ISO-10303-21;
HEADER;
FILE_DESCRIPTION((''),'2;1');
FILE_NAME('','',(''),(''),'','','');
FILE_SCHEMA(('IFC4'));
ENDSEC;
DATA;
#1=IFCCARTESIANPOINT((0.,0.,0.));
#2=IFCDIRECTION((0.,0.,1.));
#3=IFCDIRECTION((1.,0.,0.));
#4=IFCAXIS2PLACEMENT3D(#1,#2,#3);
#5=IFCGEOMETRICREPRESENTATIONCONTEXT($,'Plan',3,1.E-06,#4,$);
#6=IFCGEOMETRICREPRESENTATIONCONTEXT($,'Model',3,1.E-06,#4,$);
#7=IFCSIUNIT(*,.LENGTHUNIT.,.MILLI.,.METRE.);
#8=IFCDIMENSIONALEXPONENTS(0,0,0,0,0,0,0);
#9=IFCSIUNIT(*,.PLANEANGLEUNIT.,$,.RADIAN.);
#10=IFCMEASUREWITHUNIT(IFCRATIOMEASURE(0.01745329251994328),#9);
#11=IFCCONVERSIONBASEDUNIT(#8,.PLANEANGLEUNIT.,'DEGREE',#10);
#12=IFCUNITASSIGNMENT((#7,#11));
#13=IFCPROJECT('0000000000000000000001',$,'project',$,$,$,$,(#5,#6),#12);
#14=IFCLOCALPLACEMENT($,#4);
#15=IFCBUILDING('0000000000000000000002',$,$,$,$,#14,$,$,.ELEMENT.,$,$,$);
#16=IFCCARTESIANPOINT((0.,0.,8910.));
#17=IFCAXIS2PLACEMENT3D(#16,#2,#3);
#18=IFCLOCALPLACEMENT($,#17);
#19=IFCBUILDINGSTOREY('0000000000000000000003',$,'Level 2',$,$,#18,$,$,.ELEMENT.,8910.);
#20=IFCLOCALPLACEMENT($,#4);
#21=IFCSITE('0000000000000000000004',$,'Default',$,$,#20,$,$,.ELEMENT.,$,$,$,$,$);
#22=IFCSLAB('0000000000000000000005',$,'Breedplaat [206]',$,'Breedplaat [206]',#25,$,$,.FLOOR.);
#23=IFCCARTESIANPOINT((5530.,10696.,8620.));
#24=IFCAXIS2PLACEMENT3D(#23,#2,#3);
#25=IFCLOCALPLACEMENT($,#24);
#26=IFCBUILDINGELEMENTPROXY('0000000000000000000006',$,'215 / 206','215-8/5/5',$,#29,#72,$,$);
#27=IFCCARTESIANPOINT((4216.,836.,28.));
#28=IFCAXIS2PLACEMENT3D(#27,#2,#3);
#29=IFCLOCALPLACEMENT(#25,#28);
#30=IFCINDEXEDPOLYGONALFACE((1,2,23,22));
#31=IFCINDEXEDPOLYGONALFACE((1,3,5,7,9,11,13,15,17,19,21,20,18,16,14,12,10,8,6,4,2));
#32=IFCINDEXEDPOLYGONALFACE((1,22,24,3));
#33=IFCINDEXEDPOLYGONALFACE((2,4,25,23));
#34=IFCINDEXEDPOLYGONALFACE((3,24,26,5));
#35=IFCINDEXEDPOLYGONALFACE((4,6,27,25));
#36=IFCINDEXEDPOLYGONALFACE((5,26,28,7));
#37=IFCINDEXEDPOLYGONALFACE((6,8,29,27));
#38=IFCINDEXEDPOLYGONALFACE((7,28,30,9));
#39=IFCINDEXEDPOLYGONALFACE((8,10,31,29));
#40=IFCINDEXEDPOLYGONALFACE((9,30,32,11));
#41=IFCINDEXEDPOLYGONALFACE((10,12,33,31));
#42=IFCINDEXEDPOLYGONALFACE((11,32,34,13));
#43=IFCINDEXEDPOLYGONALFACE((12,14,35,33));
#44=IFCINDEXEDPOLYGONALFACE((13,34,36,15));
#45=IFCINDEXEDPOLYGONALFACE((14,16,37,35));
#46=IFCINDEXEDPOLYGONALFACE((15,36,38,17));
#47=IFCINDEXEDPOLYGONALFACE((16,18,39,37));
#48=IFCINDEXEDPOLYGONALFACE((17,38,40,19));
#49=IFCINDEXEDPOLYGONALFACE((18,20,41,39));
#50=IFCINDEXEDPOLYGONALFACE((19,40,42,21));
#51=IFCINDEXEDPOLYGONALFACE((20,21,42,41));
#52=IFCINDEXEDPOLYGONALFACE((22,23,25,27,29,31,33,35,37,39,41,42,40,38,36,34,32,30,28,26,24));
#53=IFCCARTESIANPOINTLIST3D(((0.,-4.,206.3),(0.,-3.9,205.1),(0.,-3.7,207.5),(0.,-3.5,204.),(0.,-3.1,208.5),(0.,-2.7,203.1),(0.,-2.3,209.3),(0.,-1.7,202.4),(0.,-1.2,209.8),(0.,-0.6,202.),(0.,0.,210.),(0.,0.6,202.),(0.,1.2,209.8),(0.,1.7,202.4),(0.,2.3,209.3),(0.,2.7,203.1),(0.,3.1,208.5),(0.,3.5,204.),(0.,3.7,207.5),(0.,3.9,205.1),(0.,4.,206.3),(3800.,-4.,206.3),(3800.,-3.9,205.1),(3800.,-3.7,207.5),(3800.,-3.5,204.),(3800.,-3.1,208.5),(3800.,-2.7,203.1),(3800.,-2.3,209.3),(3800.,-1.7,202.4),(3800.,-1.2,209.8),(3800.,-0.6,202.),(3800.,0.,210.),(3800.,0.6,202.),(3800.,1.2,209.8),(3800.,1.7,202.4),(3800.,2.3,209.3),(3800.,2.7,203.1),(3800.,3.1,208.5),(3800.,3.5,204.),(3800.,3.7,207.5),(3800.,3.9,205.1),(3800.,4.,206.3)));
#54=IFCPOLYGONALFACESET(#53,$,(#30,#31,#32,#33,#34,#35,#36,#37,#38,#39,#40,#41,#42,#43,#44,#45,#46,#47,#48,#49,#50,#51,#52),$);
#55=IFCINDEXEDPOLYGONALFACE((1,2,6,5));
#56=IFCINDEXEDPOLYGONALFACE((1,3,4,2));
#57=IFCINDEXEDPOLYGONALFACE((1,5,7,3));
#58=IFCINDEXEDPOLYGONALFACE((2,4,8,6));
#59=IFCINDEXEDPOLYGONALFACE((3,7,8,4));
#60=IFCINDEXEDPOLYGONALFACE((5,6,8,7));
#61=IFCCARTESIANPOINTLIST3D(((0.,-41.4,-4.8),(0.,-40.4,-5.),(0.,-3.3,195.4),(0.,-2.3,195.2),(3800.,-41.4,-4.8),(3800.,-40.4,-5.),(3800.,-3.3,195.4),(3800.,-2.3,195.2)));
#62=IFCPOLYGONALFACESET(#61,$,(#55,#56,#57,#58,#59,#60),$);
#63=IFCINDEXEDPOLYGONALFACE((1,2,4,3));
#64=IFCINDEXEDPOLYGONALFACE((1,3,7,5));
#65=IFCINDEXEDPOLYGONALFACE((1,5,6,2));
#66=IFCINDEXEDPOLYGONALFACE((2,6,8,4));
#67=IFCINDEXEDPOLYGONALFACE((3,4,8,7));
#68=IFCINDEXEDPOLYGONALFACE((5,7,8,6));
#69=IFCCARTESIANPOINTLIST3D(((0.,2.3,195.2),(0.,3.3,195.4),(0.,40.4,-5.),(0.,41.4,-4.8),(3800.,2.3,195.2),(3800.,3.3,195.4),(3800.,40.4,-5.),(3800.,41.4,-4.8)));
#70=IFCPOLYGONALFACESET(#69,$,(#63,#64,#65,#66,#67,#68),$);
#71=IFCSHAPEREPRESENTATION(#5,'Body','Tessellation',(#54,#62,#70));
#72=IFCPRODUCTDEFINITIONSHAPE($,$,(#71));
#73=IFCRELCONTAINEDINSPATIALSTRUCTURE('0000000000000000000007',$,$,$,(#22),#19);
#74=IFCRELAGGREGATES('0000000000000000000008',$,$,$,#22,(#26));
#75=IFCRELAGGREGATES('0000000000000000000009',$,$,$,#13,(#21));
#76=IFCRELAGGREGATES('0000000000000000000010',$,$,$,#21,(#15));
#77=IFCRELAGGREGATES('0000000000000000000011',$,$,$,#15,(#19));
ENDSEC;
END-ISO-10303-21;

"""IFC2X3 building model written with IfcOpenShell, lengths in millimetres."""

from ifc_helpers import new_model, entity, si_unit, converted_unit, frame, origin_with_axes, origin_2d_with_axis, place, context, project, spatial, rectangle, circle, extrude, element, aggregate, save


model = new_model("IFC2X3")

# Units and contexts
plan_context = context("Plan", 3, precision=1e-06, world=origin_with_axes())
model_context = context("Model", 3, precision=1e-06, world=origin_with_axes())
ifc_project = project(units=[si_unit("LENGTHUNIT", "METRE", prefix="MILLI"), converted_unit("PLANEANGLEUNIT", "DEGREE", entity("IfcRatioMeasure", 0.01745329251994328), si_unit("PLANEANGLEUNIT", "RADIAN"), dimensions=[0, 0, 0, 0, 0, 0, 0])], contexts=[plan_context, model_context])

# Site, building, storey
site_placement = place(None, origin_with_axes())
site = spatial("IfcSite", under=ifc_project, at=site_placement, Name="Default", CompositionType="ELEMENT")
building_placement = place(None, origin_with_axes())
building = spatial("IfcBuilding", under=site, at=building_placement, CompositionType="ELEMENT")
storey_placement = place(None, frame((0.0, 0.0, 8910.0), z_axis=(0.0, 0.0, 1.0), x_axis=(1.0, 0.0, 0.0)))
storey = spatial("IfcBuildingStorey", under=building, at=storey_placement, Name="Level 2", CompositionType="ELEMENT", Elevation=8910.0)

# Slab, building element proxy
slab_1_placement = place(None, frame((5530.0, 10696.0, 8620.0), z_axis=(0.0, 0.0, 1.0), x_axis=(1.0, 0.0, 0.0)))
slab_1 = element("IfcSlab", 1, at=slab_1_placement, inside=storey, Name="Breedplaat [206]", ObjectType="Breedplaat [206]", PredefinedType="FLOOR")
proxy_1_placement = place(slab_1_placement, frame((4216.0, 836.0, 28.0), z_axis=(0.0, 0.0, 1.0), x_axis=(1.0, 0.0, 0.0)))
proxy_1 = element("IfcBuildingElementProxy", 2, at=proxy_1_placement, Name="215 / 206", Description="215-8/5/5", context=plan_context, shape_type="SweptSolid", body=[
    extrude(circle(Radius=4.0, at=origin_2d_with_axis()), frame((0.0, 0.0, 206.0), z_axis=(1.0, 0.0, 0.0), x_axis=(0.0, 0.0, 1.0)), (0.0, 0.0, 1.0), 3800.0),
    extrude(rectangle(XDim=203.8, YDim=1.0, at=origin_2d_with_axis()), frame((0.0, -21.9, 95.2), z_axis=(1.0, 0.0, 0.0), x_axis=(0.0, 0.187112, 0.982339)), (0.0, 0.0, 1.0), 3800.0),
    extrude(rectangle(XDim=203.8, YDim=1.0, at=origin_2d_with_axis()), frame((0.0, 21.9, 95.2), z_axis=(1.0, 0.0, 0.0), x_axis=(0.0, -0.187112, 0.982339)), (0.0, 0.0, 1.0), 3800.0),
])
aggregate(slab_1, [proxy_1])

save(model, "model.ifc")
